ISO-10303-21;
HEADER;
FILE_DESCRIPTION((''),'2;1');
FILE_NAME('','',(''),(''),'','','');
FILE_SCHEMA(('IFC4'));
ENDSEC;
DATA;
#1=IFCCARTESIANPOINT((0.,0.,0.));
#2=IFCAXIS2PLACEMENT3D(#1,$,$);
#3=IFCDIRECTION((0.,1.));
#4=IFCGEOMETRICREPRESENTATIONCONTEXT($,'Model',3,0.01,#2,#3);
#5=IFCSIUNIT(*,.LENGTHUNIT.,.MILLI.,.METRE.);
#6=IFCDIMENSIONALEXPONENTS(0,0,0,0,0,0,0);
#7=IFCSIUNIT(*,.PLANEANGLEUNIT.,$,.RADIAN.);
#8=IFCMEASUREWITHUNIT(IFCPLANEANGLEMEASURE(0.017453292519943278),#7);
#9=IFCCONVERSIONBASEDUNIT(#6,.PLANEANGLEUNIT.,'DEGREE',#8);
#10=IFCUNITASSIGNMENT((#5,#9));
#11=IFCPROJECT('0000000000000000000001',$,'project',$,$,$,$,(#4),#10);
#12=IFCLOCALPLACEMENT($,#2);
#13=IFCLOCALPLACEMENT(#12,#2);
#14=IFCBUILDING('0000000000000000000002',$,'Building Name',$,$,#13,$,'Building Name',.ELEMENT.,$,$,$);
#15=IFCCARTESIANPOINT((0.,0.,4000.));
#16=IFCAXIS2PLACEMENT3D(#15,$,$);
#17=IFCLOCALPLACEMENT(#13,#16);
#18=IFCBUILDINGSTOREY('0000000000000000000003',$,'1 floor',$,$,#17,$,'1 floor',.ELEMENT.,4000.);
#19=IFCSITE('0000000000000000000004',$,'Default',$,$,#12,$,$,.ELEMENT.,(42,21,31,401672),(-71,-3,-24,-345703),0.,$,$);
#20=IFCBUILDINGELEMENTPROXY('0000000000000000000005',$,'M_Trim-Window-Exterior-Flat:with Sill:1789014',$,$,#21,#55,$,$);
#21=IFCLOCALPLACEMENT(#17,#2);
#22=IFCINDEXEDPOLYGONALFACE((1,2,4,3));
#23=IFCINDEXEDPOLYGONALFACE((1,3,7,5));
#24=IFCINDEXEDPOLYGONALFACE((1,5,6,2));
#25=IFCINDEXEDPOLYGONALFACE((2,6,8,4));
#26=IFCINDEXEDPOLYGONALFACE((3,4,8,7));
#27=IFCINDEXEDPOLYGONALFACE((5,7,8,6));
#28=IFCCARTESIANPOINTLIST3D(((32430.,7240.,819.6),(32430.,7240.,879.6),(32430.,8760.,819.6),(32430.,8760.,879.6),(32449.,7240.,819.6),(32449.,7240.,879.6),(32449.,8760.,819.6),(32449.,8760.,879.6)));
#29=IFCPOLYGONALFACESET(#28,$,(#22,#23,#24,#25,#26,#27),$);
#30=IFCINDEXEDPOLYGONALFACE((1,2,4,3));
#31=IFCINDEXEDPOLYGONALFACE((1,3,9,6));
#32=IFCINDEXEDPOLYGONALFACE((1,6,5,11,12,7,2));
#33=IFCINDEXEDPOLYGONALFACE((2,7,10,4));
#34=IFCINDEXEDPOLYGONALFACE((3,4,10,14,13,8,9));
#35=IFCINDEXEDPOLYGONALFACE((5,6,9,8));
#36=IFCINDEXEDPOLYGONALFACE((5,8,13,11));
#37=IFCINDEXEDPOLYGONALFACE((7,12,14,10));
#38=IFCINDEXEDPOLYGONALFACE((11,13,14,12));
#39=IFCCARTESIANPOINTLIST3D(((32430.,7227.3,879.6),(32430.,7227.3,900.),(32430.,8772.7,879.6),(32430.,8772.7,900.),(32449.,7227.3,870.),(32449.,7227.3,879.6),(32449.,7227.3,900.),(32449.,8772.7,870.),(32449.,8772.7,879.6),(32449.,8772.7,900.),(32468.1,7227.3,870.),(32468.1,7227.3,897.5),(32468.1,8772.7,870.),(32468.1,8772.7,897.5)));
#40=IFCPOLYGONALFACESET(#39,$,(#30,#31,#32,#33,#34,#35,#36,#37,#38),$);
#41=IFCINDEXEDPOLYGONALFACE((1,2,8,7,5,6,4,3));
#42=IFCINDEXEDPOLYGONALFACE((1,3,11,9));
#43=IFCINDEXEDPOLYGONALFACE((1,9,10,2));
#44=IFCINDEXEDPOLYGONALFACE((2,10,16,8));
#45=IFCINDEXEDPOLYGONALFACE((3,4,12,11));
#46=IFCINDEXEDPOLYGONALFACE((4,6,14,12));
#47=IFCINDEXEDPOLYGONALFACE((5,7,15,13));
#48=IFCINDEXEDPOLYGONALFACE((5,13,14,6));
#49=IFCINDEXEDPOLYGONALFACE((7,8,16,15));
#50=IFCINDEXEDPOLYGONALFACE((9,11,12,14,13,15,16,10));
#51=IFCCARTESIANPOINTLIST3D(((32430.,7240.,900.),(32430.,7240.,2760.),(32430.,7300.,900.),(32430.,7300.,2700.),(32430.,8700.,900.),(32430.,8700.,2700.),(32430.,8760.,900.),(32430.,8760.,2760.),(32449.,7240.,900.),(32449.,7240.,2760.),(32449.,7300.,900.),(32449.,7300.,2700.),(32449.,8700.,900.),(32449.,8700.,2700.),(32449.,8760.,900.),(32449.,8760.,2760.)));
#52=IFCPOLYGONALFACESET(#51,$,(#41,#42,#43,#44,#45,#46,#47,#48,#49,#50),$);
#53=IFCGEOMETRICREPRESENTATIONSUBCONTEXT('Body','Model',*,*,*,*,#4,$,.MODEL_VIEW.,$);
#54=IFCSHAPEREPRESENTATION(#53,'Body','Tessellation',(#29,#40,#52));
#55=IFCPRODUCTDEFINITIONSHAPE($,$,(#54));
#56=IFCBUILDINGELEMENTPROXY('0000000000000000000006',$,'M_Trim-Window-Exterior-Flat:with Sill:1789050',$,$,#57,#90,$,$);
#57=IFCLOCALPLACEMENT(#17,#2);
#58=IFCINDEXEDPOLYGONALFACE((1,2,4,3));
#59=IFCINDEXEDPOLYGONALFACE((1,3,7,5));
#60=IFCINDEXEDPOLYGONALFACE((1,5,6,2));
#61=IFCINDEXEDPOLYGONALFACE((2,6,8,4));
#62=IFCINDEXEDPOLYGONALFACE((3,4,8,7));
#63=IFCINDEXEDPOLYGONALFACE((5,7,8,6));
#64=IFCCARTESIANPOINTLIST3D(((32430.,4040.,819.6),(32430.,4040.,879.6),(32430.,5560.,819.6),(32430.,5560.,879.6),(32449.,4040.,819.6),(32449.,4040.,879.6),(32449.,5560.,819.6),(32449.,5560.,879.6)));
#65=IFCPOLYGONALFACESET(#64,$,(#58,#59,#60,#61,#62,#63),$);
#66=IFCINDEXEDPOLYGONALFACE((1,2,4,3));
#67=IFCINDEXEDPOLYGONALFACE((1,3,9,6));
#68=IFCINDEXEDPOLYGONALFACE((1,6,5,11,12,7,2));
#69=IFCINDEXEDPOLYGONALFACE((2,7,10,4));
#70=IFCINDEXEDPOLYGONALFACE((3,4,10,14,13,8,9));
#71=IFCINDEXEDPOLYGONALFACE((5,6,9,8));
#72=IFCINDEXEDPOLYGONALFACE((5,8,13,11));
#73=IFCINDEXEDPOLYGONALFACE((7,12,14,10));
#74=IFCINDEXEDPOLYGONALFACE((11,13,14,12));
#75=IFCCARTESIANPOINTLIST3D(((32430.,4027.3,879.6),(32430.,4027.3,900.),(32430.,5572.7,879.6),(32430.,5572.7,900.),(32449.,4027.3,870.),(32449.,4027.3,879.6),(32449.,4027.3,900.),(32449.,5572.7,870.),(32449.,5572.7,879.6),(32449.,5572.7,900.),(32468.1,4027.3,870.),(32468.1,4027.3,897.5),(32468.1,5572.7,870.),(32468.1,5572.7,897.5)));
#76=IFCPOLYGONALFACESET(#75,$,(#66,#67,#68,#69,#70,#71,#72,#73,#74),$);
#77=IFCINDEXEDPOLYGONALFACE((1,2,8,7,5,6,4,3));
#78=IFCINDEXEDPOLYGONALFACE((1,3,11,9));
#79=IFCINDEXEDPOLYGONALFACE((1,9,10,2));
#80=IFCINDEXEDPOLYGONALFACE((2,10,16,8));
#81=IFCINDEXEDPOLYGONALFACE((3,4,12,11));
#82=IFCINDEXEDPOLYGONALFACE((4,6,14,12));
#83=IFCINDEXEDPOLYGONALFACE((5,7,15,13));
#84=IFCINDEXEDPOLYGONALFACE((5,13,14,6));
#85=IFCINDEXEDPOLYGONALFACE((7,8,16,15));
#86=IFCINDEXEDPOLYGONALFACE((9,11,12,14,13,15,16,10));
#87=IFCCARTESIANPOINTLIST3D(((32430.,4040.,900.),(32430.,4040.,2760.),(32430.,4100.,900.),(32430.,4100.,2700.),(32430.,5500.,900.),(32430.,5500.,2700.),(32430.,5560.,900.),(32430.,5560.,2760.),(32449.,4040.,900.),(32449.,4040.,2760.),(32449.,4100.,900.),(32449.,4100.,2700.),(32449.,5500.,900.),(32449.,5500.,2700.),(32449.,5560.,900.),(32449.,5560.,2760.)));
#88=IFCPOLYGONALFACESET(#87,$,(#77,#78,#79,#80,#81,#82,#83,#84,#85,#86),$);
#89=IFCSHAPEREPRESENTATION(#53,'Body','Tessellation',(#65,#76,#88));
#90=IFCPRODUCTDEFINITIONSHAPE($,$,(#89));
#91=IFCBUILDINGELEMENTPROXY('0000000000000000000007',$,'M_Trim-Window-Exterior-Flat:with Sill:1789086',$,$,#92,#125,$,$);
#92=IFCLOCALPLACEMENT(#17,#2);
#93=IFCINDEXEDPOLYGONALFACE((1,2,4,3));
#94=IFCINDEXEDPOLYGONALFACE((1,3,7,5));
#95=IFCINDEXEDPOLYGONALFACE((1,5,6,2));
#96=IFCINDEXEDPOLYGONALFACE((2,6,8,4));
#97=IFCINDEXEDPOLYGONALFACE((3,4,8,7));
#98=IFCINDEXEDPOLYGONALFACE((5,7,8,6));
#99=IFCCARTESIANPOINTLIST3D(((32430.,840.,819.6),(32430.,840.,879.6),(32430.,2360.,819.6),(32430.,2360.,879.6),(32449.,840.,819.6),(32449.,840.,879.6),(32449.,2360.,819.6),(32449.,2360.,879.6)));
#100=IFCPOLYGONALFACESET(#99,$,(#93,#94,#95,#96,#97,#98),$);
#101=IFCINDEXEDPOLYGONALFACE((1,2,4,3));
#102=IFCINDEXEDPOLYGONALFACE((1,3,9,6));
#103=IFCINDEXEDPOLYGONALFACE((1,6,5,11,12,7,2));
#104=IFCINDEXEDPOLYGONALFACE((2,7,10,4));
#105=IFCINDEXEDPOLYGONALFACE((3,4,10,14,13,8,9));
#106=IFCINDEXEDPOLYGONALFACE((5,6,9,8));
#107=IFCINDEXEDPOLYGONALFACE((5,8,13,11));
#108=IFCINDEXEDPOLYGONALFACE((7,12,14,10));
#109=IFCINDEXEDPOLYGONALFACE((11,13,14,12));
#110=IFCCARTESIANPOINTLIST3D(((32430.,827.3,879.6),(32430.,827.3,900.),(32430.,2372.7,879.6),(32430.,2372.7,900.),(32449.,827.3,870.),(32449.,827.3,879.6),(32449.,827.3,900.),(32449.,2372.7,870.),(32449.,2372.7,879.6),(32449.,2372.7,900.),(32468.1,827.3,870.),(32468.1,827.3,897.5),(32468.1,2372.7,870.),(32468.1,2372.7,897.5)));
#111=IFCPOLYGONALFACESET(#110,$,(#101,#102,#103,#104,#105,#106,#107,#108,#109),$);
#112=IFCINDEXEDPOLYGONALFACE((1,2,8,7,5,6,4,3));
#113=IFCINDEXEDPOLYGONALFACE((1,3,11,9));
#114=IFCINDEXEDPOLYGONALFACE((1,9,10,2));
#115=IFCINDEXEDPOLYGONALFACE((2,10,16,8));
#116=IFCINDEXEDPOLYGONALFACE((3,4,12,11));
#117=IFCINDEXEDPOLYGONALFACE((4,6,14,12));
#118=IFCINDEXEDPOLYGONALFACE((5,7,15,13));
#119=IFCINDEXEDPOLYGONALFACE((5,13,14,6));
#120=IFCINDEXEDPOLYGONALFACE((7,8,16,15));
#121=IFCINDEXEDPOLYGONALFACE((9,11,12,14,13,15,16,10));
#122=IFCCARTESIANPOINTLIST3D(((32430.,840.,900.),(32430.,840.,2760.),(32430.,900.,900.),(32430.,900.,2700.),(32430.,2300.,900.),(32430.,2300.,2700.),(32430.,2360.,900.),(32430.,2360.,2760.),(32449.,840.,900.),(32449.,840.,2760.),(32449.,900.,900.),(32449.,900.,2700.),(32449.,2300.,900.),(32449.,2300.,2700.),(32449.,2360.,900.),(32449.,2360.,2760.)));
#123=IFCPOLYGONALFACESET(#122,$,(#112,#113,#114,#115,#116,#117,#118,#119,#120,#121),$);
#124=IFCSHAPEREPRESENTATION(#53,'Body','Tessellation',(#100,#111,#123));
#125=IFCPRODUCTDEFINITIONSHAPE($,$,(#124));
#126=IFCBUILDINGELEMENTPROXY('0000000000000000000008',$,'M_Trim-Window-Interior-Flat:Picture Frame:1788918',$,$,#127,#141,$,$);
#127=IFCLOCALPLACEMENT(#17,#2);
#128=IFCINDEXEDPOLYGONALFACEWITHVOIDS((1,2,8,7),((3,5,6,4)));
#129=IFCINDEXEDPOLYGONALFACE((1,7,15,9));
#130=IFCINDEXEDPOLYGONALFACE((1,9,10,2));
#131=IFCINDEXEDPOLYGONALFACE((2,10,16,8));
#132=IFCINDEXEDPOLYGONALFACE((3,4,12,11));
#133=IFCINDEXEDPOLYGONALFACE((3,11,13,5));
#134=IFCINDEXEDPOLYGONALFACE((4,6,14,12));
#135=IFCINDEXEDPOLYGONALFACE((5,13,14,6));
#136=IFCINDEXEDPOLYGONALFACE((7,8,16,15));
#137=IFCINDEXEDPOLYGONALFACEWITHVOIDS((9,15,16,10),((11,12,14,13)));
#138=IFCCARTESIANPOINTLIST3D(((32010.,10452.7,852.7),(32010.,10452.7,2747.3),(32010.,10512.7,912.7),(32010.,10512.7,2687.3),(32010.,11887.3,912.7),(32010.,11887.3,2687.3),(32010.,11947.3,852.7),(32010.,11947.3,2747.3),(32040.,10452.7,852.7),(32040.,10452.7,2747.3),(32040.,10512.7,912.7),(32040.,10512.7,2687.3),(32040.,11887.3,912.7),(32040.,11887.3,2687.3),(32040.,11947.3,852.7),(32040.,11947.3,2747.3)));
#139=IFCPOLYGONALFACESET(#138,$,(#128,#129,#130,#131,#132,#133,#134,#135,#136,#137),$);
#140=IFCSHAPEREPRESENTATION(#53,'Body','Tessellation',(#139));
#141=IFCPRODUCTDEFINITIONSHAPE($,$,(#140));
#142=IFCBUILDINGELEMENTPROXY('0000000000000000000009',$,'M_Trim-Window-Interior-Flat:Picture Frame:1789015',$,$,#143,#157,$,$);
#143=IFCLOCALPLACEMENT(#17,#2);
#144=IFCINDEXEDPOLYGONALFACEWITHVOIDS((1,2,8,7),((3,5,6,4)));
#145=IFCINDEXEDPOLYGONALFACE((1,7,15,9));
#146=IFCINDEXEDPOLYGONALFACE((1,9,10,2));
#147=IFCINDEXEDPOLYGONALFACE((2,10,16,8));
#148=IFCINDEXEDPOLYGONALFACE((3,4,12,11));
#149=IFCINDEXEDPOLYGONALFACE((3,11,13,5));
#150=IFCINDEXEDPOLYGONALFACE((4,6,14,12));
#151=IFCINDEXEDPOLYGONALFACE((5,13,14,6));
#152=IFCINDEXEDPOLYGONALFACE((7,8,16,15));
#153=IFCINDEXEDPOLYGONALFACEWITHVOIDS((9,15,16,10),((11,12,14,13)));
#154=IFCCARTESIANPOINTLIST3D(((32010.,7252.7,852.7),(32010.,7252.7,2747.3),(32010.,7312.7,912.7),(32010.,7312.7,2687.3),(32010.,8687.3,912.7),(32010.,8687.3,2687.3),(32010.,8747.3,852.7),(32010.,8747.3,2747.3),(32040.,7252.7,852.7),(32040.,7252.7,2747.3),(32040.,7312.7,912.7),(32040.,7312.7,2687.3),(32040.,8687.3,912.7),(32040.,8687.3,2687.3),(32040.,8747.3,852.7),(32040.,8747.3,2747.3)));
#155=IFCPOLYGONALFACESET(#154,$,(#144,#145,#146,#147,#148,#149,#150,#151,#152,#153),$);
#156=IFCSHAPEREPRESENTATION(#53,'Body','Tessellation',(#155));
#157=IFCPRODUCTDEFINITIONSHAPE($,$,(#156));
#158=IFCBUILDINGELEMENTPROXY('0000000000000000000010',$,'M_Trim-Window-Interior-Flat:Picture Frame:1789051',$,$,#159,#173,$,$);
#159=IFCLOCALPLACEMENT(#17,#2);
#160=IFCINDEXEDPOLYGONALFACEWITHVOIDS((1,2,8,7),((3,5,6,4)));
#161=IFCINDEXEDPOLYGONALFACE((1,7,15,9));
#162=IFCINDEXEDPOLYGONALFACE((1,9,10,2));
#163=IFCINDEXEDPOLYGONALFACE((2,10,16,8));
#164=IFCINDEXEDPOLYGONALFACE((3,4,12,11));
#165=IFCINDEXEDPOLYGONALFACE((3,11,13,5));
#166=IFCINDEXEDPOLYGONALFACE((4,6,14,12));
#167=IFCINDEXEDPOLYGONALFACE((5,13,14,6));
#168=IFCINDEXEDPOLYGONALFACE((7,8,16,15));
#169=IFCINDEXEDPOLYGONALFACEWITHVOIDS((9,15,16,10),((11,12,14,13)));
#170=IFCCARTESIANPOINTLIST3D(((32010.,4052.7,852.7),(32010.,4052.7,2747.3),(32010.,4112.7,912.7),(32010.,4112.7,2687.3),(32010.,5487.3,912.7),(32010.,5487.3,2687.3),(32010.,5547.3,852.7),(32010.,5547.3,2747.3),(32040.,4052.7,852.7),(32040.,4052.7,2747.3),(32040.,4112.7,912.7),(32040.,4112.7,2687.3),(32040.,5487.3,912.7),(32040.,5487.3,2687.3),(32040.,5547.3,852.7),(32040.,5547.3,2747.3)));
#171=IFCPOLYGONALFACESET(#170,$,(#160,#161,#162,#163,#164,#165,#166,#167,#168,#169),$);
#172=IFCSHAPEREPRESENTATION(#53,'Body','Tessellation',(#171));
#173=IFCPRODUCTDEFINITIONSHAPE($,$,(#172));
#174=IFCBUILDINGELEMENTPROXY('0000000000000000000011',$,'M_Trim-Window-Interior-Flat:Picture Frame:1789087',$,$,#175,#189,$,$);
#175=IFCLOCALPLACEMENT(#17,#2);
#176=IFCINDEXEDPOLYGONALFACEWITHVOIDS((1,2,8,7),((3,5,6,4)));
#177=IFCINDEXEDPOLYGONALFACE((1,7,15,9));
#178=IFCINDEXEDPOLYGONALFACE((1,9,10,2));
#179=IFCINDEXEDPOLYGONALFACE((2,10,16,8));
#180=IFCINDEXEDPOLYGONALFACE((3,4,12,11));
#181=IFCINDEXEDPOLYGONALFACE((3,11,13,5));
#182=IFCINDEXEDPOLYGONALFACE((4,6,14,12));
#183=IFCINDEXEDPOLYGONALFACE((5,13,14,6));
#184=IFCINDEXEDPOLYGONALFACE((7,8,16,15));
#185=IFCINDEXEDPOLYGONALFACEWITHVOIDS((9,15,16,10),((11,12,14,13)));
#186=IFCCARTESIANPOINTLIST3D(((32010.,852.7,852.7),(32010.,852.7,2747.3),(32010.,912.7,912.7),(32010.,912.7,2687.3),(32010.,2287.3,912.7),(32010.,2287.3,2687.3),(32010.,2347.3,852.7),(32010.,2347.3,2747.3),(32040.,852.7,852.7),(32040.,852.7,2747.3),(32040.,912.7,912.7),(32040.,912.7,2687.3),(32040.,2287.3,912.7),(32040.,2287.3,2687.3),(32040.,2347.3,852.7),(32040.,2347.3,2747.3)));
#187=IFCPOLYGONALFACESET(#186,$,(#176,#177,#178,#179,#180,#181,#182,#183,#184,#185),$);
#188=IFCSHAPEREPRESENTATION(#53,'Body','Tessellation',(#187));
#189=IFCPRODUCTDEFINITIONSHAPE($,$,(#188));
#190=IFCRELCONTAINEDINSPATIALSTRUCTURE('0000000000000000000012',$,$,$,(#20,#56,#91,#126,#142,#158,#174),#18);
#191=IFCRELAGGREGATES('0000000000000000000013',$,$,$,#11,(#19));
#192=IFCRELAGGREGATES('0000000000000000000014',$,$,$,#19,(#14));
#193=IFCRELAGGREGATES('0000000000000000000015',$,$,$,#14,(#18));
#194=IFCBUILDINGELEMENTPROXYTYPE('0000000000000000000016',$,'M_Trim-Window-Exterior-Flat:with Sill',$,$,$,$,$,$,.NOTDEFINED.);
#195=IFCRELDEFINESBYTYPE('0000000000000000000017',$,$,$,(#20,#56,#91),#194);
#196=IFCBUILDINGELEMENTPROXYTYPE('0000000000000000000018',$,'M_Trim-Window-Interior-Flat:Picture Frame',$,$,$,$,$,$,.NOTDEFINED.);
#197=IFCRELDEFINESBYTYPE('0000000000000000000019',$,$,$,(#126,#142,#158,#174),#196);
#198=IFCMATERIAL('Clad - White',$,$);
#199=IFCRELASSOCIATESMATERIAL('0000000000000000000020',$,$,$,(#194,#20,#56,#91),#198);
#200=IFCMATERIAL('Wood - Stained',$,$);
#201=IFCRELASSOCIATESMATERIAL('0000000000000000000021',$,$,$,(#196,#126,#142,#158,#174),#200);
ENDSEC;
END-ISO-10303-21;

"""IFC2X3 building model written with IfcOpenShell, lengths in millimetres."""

from ifc_helpers import new_model, entity, si_unit, converted_unit, direction, frame, frame_2d, origin, place, context, subcontext, project, spatial, polyline, rectangle, outline, extrude, source, transform, mapped, material, type_object, type_shapes, element, save


model = new_model("IFC2X3")

# Units and contexts
model_context = context("Model", 3, precision=0.01, world=origin(), true_north=direction((0.0, 1.0)))
body_context = subcontext(model_context, "Body", "Model", "MODEL_VIEW")
ifc_project = project(units=[si_unit("LENGTHUNIT", "METRE", prefix="MILLI"), converted_unit("PLANEANGLEUNIT", "DEGREE", entity("IfcPlaneAngleMeasure", 0.017453292519943278), si_unit("PLANEANGLEUNIT", "RADIAN"), dimensions=[0, 0, 0, 0, 0, 0, 0])], contexts=[model_context])

# Site, building, storey
site_placement = place(None, origin())
site = spatial("IfcSite", under=ifc_project, at=site_placement, Name="Default", CompositionType="ELEMENT", RefLatitude=(42, 21, 31, 401672), RefLongitude=(-71, -3, -24, -345703), RefElevation=0.0)
building_placement = place(site_placement, origin())
building = spatial("IfcBuilding", under=site, at=building_placement, Name="Building Name", LongName="Building Name", CompositionType="ELEMENT")
storey_placement = place(building_placement, frame((0.0, 0.0, 4000.0)))
storey = spatial("IfcBuildingStorey", under=building, at=storey_placement, Name="1 floor", LongName="1 floor", CompositionType="ELEMENT", Elevation=4000.0)

# Building element proxies
ifc_material_1 = material(Name="Clad - White")
ifc_material_2 = material(Name="Wood - Stained")
building_element_proxy_type_1 = type_object("IfcBuildingElementProxyType", Name="M_Trim-Window-Exterior-Flat:with Sill", PredefinedType="NOTDEFINED", material=ifc_material_1)
shared_shape_1 = source(origin(), body_context, "Body", "SweptSolid", [
    extrude(rectangle(XDim=1520.0, YDim=60.0, at=frame_2d((0.0, 0.0), x_axis=(1.0, 0.0))), frame((0.0, -1850.4, 0.0), z_axis=(0.0, 0.0, 1.0), x_axis=(-1.0, 0.0, 0.0)), (0.0, 0.0, 1.0), 19.0),
    extrude(outline(polyline([(-19.0, -15.2), (0.0, -15.2), (0.0, -5.7), (19.0, -5.7), (19.0, 14.8), (0.0, 14.8), (-19.0, 12.3), (-19.0, -15.2)])), frame((-772.7, -1814.8, 19.0), z_axis=(1.0, 0.0, 0.0), x_axis=(0.0, 0.0, -1.0)), (0.0, 0.0, 1.0), 1545.4),
    extrude(outline(polyline([(-945.0, -760.0), (915.0, -760.0), (915.0, -700.0), (-885.0, -700.0), (-885.0, 700.0), (915.0, 700.0), (915.0, 760.0), (-945.0, 760.0), (-945.0, -760.0)])), frame((0.0, -885.0, 0.0), z_axis=(0.0, 0.0, 1.0), x_axis=(0.0, -1.0, 0.0)), (0.0, 0.0, 1.0), 19.0),
])
type_shapes(building_element_proxy_type_1, [shared_shape_1])
for number, where, z_axis, x_axis, name in (
    (1, (32430.0, 8000.0, 2700.0), (1.0, 0.0, 0.0), (0.0, 1.0, 0.0), "M_Trim-Window-Exterior-Flat:with Sill:1789014"),
    (2, (32430.0, 4800.0, 2700.0), (1.0, 0.0, 0.0), (0.0, 1.0, 0.0), "M_Trim-Window-Exterior-Flat:with Sill:1789050"),
    (3, (32430.0, 1600.0, 2700.0), (1.0, 0.0, 0.0), (0.0, 1.0, 0.0), "M_Trim-Window-Exterior-Flat:with Sill:1789086"),
):
    element("IfcBuildingElementProxy", number, at=place(storey_placement, frame(where, z_axis=z_axis, x_axis=x_axis)), inside=storey, type_object=building_element_proxy_type_1, material=ifc_material_1, Name=name, context=body_context, shape_type="MappedRepresentation", body=[
        mapped(shared_shape_1, transform((0.0, 0.0, 0.0), scale=1.0)),
    ])
building_element_proxy_type_2 = type_object("IfcBuildingElementProxyType", Name="M_Trim-Window-Interior-Flat:Picture Frame", PredefinedType="NOTDEFINED", material=ifc_material_2)
shared_shape_2 = source(origin(), body_context, "Body", "SweptSolid", [
    extrude(outline(polyline([(-747.3, -947.3), (747.3, -947.3), (747.3, 947.3), (-747.3, 947.3), (-747.3, -947.3)]), holes=[polyline([(-687.3, -887.3), (-687.3, 887.3), (687.3, 887.3), (687.3, -887.3), (-687.3, -887.3)])]), frame((0.0, -900.0, 0.0), z_axis=(0.0, 0.0, 1.0), x_axis=(-1.0, 0.0, 0.0)), (0.0, 0.0, 1.0), 30.0),
])
type_shapes(building_element_proxy_type_2, [shared_shape_2])
for number, where, z_axis, x_axis, name in (
    (4, (32040.0, 11200.0, 2700.0), (-1.0, 0.0, 0.0), (0.0, -1.0, 0.0), "M_Trim-Window-Interior-Flat:Picture Frame:1788918"),
    (5, (32040.0, 8000.0, 2700.0), (-1.0, 0.0, 0.0), (0.0, -1.0, 0.0), "M_Trim-Window-Interior-Flat:Picture Frame:1789015"),
    (6, (32040.0, 4800.0, 2700.0), (-1.0, 0.0, 0.0), (0.0, -1.0, 0.0), "M_Trim-Window-Interior-Flat:Picture Frame:1789051"),
    (7, (32040.0, 1600.0, 2700.0), (-1.0, 0.0, 0.0), (0.0, -1.0, 0.0), "M_Trim-Window-Interior-Flat:Picture Frame:1789087"),
):
    element("IfcBuildingElementProxy", number, at=place(storey_placement, frame(where, z_axis=z_axis, x_axis=x_axis)), inside=storey, type_object=building_element_proxy_type_2, material=ifc_material_2, Name=name, context=body_context, shape_type="MappedRepresentation", body=[
        mapped(shared_shape_2, transform((0.0, 0.0, 0.0), scale=1.0)),
    ])

save(model, "model.ifc")
